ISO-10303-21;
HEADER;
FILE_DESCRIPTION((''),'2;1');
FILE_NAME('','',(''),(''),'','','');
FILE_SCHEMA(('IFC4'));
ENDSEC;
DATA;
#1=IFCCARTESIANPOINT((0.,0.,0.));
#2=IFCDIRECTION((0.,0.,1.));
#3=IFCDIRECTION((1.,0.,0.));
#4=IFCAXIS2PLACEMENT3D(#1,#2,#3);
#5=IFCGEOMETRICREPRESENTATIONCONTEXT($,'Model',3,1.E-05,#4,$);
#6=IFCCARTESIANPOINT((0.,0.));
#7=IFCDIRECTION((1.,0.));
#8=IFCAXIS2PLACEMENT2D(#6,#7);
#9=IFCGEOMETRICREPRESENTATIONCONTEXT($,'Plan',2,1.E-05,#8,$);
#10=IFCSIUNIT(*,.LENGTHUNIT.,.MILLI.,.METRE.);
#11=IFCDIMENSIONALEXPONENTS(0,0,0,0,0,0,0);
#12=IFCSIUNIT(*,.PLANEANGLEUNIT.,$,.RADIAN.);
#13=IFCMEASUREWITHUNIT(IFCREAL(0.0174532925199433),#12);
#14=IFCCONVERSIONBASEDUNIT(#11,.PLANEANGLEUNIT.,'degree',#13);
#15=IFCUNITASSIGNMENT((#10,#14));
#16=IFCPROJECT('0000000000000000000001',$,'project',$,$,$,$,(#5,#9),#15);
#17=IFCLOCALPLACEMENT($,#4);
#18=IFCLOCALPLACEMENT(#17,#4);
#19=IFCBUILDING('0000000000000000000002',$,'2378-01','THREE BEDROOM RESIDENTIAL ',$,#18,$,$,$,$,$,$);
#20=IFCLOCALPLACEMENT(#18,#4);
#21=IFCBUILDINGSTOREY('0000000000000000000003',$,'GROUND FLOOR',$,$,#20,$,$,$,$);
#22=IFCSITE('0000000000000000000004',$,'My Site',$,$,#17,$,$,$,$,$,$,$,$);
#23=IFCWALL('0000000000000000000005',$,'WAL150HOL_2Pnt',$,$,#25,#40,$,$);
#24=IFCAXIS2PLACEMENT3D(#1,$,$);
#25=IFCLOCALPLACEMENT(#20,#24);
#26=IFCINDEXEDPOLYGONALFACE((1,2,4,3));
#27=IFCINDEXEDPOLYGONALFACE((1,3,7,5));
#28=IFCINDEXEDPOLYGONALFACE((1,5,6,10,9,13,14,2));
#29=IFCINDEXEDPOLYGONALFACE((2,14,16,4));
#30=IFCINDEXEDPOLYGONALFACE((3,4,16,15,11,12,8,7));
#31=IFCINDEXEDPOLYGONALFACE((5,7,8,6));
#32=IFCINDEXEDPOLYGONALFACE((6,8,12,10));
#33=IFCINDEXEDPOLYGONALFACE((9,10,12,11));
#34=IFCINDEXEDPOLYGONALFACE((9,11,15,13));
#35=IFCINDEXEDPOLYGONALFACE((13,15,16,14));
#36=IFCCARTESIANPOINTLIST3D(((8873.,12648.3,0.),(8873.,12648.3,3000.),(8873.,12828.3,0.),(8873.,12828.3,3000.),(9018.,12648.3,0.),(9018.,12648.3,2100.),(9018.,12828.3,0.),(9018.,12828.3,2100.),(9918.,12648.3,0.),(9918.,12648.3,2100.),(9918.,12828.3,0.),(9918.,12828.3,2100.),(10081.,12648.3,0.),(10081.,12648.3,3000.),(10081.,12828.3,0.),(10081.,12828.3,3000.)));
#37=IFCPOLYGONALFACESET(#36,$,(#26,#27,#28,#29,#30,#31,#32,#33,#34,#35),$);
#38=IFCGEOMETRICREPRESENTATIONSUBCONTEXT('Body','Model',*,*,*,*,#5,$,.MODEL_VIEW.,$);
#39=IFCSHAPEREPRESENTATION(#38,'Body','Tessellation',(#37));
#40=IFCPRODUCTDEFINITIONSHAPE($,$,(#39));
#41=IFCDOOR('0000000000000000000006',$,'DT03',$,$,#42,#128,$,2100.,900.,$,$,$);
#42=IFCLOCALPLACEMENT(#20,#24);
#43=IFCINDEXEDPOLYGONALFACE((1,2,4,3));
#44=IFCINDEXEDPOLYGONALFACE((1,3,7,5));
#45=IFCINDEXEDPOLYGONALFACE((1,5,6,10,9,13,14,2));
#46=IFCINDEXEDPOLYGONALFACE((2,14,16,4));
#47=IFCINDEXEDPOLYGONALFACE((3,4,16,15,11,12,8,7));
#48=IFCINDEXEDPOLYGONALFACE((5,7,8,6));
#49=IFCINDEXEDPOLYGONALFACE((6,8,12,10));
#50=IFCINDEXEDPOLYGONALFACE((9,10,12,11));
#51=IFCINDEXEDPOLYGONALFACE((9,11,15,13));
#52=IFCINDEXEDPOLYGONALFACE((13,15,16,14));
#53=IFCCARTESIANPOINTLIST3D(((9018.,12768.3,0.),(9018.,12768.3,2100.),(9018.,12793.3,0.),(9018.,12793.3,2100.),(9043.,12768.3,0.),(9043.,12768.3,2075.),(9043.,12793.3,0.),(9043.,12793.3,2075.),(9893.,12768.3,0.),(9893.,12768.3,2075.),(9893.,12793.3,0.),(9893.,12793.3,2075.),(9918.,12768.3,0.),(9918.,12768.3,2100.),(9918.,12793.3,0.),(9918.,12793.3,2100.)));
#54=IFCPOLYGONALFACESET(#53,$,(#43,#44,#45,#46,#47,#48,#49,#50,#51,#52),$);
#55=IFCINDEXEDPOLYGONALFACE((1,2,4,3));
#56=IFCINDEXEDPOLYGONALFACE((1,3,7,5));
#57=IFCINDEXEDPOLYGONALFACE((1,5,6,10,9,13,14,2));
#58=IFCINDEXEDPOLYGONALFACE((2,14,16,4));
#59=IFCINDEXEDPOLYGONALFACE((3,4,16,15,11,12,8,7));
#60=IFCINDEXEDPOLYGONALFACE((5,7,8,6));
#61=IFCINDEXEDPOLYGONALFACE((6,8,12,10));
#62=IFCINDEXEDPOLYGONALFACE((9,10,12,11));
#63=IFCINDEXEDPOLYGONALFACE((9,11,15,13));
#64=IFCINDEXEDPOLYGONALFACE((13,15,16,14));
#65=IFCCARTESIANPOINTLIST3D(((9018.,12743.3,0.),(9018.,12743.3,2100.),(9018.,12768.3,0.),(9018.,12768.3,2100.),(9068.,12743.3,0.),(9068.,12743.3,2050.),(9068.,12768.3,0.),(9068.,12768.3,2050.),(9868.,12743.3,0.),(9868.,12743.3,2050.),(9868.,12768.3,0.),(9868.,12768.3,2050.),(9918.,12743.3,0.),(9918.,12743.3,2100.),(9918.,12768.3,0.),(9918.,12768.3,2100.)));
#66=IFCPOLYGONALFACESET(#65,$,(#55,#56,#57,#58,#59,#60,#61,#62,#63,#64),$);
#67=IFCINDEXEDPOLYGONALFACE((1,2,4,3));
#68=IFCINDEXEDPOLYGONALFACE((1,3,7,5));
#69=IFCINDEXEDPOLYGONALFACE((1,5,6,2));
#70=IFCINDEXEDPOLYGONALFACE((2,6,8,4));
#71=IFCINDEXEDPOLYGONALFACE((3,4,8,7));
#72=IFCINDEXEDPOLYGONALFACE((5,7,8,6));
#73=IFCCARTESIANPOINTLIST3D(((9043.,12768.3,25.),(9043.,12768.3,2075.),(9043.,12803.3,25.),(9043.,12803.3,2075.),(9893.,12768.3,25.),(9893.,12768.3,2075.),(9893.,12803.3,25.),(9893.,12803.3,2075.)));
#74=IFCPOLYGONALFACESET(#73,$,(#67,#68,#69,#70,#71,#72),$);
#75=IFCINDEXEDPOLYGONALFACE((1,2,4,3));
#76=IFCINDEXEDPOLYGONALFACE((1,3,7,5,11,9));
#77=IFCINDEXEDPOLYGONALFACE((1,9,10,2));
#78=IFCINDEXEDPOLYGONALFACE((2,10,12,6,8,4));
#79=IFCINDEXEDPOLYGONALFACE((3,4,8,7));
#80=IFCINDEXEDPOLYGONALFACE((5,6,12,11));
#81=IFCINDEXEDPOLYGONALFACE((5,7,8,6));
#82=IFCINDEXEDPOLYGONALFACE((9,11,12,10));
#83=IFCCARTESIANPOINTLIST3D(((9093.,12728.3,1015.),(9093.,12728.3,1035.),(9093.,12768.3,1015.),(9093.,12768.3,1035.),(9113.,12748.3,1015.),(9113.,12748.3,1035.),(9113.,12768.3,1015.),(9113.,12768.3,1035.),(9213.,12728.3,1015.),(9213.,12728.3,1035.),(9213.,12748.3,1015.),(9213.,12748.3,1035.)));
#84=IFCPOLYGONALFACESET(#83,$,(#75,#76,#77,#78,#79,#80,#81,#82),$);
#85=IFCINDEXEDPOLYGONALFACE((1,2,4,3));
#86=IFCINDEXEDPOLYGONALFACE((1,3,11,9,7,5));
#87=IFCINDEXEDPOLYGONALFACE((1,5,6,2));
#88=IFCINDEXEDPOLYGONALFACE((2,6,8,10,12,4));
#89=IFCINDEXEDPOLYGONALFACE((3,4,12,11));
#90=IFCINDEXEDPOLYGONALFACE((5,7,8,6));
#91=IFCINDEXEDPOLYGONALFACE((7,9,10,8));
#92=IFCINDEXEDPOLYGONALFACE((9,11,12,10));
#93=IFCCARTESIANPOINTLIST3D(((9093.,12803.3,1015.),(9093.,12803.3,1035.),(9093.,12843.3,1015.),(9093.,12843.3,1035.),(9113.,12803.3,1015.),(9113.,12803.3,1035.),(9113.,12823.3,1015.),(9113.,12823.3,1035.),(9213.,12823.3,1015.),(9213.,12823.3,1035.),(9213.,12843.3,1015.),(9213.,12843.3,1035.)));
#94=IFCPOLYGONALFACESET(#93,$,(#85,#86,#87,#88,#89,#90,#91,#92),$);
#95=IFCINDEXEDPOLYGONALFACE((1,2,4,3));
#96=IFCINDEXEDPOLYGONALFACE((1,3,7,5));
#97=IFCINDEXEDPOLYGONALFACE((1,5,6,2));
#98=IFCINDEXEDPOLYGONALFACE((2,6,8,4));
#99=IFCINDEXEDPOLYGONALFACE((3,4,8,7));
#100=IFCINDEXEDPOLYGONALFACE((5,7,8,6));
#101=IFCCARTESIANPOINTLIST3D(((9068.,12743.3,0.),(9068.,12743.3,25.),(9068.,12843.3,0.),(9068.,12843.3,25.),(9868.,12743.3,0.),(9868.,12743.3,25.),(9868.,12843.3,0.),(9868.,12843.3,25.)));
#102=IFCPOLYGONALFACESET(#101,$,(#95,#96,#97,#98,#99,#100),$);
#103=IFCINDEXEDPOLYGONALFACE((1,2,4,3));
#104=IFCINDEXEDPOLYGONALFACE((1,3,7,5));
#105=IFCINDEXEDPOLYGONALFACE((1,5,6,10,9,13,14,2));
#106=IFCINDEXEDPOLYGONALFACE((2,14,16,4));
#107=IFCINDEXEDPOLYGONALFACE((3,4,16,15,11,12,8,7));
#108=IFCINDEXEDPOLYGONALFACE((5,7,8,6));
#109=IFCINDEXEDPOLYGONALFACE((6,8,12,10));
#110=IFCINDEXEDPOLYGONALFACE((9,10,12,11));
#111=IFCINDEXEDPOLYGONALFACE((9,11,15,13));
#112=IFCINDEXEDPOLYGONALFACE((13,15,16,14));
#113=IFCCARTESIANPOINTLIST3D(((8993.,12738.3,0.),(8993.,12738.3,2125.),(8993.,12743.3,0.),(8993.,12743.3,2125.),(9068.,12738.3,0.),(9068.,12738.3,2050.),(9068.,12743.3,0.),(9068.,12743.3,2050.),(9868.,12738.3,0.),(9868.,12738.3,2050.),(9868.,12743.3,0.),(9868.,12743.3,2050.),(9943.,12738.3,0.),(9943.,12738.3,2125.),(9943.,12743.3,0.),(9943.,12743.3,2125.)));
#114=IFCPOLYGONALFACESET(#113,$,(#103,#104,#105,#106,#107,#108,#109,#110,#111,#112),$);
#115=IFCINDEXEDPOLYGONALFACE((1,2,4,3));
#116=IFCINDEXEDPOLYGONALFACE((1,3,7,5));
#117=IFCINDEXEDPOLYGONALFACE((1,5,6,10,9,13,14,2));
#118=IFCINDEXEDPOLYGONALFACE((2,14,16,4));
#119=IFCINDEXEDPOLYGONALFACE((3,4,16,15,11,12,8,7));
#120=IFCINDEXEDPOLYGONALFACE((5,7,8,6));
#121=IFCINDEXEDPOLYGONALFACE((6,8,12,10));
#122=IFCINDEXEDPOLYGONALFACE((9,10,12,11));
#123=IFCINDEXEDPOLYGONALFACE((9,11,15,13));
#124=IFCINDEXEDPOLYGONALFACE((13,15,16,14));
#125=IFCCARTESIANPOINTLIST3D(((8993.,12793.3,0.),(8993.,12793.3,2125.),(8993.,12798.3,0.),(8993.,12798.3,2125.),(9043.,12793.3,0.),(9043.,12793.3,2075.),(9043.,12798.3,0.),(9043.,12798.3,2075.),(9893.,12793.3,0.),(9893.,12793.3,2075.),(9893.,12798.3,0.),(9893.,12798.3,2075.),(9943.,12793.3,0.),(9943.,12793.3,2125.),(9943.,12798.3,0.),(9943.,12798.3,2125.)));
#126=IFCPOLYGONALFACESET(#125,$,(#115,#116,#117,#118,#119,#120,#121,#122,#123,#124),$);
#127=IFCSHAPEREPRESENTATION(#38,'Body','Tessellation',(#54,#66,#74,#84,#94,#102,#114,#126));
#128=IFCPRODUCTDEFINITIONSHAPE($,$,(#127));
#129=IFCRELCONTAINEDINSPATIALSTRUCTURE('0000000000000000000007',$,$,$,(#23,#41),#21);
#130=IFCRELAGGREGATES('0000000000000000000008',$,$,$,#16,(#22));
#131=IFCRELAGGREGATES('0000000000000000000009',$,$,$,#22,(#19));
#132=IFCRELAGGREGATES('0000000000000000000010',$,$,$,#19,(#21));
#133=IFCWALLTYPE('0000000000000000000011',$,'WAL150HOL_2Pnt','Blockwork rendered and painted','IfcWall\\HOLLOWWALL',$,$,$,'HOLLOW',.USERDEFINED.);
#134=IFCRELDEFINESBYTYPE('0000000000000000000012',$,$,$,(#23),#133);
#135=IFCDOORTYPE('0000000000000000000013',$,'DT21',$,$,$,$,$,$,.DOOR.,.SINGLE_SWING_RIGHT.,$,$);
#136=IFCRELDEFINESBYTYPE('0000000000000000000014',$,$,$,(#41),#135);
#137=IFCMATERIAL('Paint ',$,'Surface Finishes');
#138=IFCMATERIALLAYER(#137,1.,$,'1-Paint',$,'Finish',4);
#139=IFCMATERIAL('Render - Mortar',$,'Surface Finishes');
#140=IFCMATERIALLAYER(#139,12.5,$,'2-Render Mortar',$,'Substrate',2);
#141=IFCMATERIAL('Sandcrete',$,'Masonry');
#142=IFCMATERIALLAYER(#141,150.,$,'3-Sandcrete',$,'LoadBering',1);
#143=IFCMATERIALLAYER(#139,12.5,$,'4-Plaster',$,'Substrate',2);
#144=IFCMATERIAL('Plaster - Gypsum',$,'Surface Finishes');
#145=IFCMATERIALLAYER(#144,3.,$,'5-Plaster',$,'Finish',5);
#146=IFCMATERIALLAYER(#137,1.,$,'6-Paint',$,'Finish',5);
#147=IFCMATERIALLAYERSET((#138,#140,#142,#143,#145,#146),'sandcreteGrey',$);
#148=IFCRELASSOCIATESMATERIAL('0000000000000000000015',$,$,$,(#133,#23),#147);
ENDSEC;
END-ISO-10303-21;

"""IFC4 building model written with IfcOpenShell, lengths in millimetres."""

from ifc_helpers import new_model, entity, si_unit, converted_unit, frame, origin_with_axes, origin_2d_with_axis, place, context, subcontext, project, spatial, line, indexed_curve, outline, extrude, shape, source, transform, mapped, material, layer, layer_set, layer_usage, type_object, type_shapes, element, fill, save


model = new_model("IFC4")

# Units and contexts
model_context = context("Model", 3, precision=1e-05, world=origin_with_axes())
plan_context = context("Plan", 2, precision=1e-05, world=origin_2d_with_axis())
body_context_1 = subcontext(model_context, "Body", "Model", "MODEL_VIEW")
body_context_2 = subcontext(plan_context, "Body", "Plan", "PLAN_VIEW")
ifc_project = project(units=[si_unit("LENGTHUNIT", "METRE", prefix="MILLI"), converted_unit("PLANEANGLEUNIT", "degree", entity("IfcReal", 0.0174532925199433), si_unit("PLANEANGLEUNIT", "RADIAN"), dimensions=[0, 0, 0, 0, 0, 0, 0])], contexts=[model_context, plan_context])

# Site, building, storey
site_placement = place(None, origin_with_axes())
site = spatial("IfcSite", under=ifc_project, at=site_placement, Name="My Site")
building_placement = place(site_placement, origin_with_axes())
building = spatial("IfcBuilding", under=site, at=building_placement, Name="2378-01", Description="THREE BEDROOM RESIDENTIAL ")
storey_placement = place(building_placement, origin_with_axes())
storey = spatial("IfcBuildingStorey", under=building, at=storey_placement, Name="GROUND FLOOR")

# Shared definitions
ifc_material_1 = material(Name="Paint ", Category="Surface Finishes")
ifc_layer_1 = layer(ifc_material_1, 1.0, Name="1-Paint", Category="Finish", Priority=4)
ifc_material_2 = material(Name="Render - Mortar", Category="Surface Finishes")
ifc_layer_2 = layer(ifc_material_2, 12.5, Name="2-Render Mortar", Category="Substrate", Priority=2)
ifc_material_3 = material(Name="Sandcrete", Category="Masonry")
ifc_layer_3 = layer(ifc_material_3, 150.0, Name="3-Sandcrete", Category="LoadBering", Priority=1)
ifc_layer_4 = layer(ifc_material_2, 12.5, Name="4-Plaster", Category="Substrate", Priority=2)
ifc_material_4 = material(Name="Plaster - Gypsum", Category="Surface Finishes")
ifc_layer_5 = layer(ifc_material_4, 3.0, Name="5-Plaster", Category="Finish", Priority=5)
ifc_layer_6 = layer(ifc_material_1, 1.0, Name="6-Paint", Category="Finish", Priority=5)
ifc_layer_set_1 = layer_set([ifc_layer_1, ifc_layer_2, ifc_layer_3, ifc_layer_4, ifc_layer_5, ifc_layer_6], Name="sandcreteGrey")
wall_type_1 = type_object("IfcWallType", Name="WAL150HOL_2Pnt", Description="Blockwork rendered and painted", ApplicableOccurrence="IfcWall\\HOLLOWWALL", ElementType="HOLLOW", PredefinedType="USERDEFINED", material=ifc_layer_set_1)

# Shared definitions
shared_shape_1 = source(origin_with_axes(), body_context_1, "Body", "SweptSolid", [
    extrude(outline(indexed_curve([(0.0, 0.0), (900.0, 0.0), (900.0, 2100.0), (0.0, 2100.0)], segments=[line(1, 2, 3, 4, 1)])), frame((0.0, -600.0, 0.0), z_axis=(0.0, -1.0, 0.0), x_axis=(1.0, 0.0, 0.0)), (0.0, 0.0, -1.0), 1200.0),
])
door_type_1 = type_object("IfcDoorType", Name="DT21", OperationType="SINGLE_SWING_RIGHT", PredefinedType="DOOR")
shared_shape_2 = source(origin_with_axes(), body_context_1, "Body", "SweptSolid", [
    extrude(outline(indexed_curve([(0.0, 0.0), (0.0, 2100.0), (900.0, 2100.0), (900.0, 0.0), (875.0, 0.0), (875.0, 2075.0), (25.0, 2075.0), (25.0, 0.0)], segments=[line(1, 2, 3, 4, 5, 6, 7, 8, 1)])), frame((0.0, 25.0, 0.0), z_axis=(0.0, -1.0, 0.0), x_axis=(1.0, 0.0, 0.0)), (0.0, 0.0, -1.0), 25.0),
    extrude(outline(indexed_curve([(0.0, 0.0), (0.0, 2100.0), (900.0, 2100.0), (900.0, 0.0), (850.0, 0.0), (850.0, 2050.0), (50.0, 2050.0), (50.0, 0.0)], segments=[line(1, 2, 3, 4, 5, 6, 7, 8, 1)])), frame((0.0, 0.0, 0.0), z_axis=(0.0, -1.0, 0.0), x_axis=(1.0, 0.0, 0.0)), (0.0, 0.0, -1.0), 25.0),
    extrude(outline(indexed_curve([(0.0, 0.0), (850.0, 0.0), (850.0, 35.0), (0.0, 35.0)], segments=[line(1, 2, 3, 4, 1)])), frame((25.0, 25.0, 25.0), z_axis=(0.0, 0.0, 1.0), x_axis=(1.0, 0.0, 0.0)), (0.0, 0.0, 1.0), 2050.0),
    extrude(outline(indexed_curve([(0.0, 0.0), (0.0, -40.0), (120.0, -40.0), (120.0, -20.0), (20.0, -20.0), (20.0, 0.0)], segments=[line(1, 2, 3, 4, 5, 6, 1)])), frame((75.0, 25.0, 1015.0), z_axis=(0.0, 0.0, 1.0), x_axis=(1.0, 0.0, 0.0)), (0.0, 0.0, 1.0), 20.0),
    extrude(outline(indexed_curve([(0.0, 0.0), (0.0, 40.0), (120.0, 40.0), (120.0, 20.0), (20.0, 20.0), (20.0, 0.0)], segments=[line(1, 2, 3, 4, 5, 6, 1)])), frame((75.0, 60.0, 1015.0), z_axis=(0.0, 0.0, 1.0), x_axis=(1.0, 0.0, 0.0)), (0.0, 0.0, 1.0), 20.0),
    extrude(outline(indexed_curve([(0.0, 0.0), (800.0, 0.0), (800.0, 100.0), (0.0, 100.0)], segments=[line(1, 2, 3, 4, 1)])), frame((50.0, 0.0, 0.0), z_axis=(0.0, 0.0, 1.0), x_axis=(1.0, 0.0, 0.0)), (0.0, 0.0, 1.0), 25.0),
    extrude(outline(indexed_curve([(0.0, 0.0), (0.0, 2125.0), (950.0, 2125.0), (950.0, 0.0), (875.0, 0.0), (875.0, 2050.0), (75.0, 2050.0), (75.0, 0.0)], segments=[line(1, 2, 3, 4, 5, 6, 7, 8, 1)])), frame((-25.0, -5.0, 0.0), z_axis=(0.0, -1.0, 0.0), x_axis=(1.0, 0.0, 0.0)), (0.0, 0.0, -1.0), 5.0),
    extrude(outline(indexed_curve([(0.0, 0.0), (0.0, 2125.0), (950.0, 2125.0), (950.0, 0.0), (900.0, 0.0), (900.0, 2075.0), (50.0, 2075.0), (50.0, 0.0)], segments=[line(1, 2, 3, 4, 5, 6, 7, 8, 1)])), frame((-25.0, 50.0, 0.0), z_axis=(0.0, -1.0, 0.0), x_axis=(1.0, 0.0, 0.0)), (0.0, 0.0, -1.0), 5.0),
])
shared_shape_3 = source(origin_with_axes(), body_context_2, "Body", "Curve2D", [
    entity("IfcIndexedPolyCurve", entity("IfcCartesianPointList2D", [[0.0, 0.0], [0.0, 50.0], [25.0, 50.0], [25.0, 25.0], [50.0, 25.0], [50.0, 0.0]]), [entity("IfcLineIndex", [1, 2, 3, 4, 5, 6, 1])]),
    entity("IfcIndexedPolyCurve", entity("IfcCartesianPointList2D", [[900.0, 0.0], [900.0, 50.0], [875.0, 50.0], [875.0, 25.0], [850.0, 25.0], [850.0, 0.0]]), [entity("IfcLineIndex", [1, 2, 3, 4, 5, 6, 1])]),
    entity("IfcTrimmedCurve", entity("IfcEllipse", entity("IfcAxis2Placement2D", entity("IfcCartesianPoint", [840.0, 50.0]), entity("IfcDirection", [1.0, 0.0])), 815.0, 850.0), [entity("IfcCartesianPoint", [840.0, 900.0])], [entity("IfcCartesianPoint", [25.0, 50.0])], True, "CARTESIAN"),
    entity("IfcIndexedPolyCurve", entity("IfcCartesianPointList2D", [[875.0, 50.0], [840.0, 50.0], [840.0, 900.0], [875.0, 900.0]]), [entity("IfcLineIndex", [1, 2, 3, 4, 1])]),
])
type_shapes(door_type_1, [shared_shape_2, shared_shape_3])

# Wall, opening, door
ifc_layer_usage_1 = layer_usage(ifc_layer_set_1, "AXIS2", "POSITIVE", 0.0)
wall_1_placement = place(storey_placement, frame((10081.0, 12828.3, 0.0), z_axis=(0.0, 0.0, 1.0), x_axis=(-1.0, 0.000001, 0.0)))
wall_1 = element("IfcWall", 1, at=wall_1_placement, inside=storey, type_object=wall_type_1, material=ifc_layer_usage_1, Name="WAL150HOL_2Pnt", context=body_context_1, shape_type="SweptSolid", body=[
    extrude(outline(indexed_curve([(0.0, 0.0), (0.0, 180.0), (1208.0, 180.0), (1208.0, 0.0), (0.0, 0.0)], self_intersect=False)), origin_with_axes(), (0.0, 0.0, 1.0), 3000.0),
])
opening_1_placement = place(wall_1_placement, frame((1063.0, 85.0, 0.0), z_axis=(0.0, 0.0, 1.0), x_axis=(-1.0, 0.0, 0.0)))
opening_1 = element("IfcOpeningElement", 2, at=opening_1_placement, cuts=wall_1, PredefinedType="OPENING", context=body_context_1, shape_type="MappedRepresentation", body=[
    mapped(shared_shape_1, transform((0.0, 0.0, 0.0), x_axis=(1.0, 0.0, 0.0), y_axis=(0.0, 1.0, 0.0), z_axis=(0.0, 0.0, 1.0), scale=1.0)),
])
door_1_placement = place(opening_1_placement, origin_with_axes())
door_1 = element("IfcDoor", 3, at=door_1_placement, inside=storey, type_object=door_type_1, Name="DT03", OverallHeight=2100.0, OverallWidth=900.0, shapes=[
    shape(body_context_1, "Body", "MappedRepresentation", [mapped(shared_shape_2, transform((0.0, 0.0, 0.0), x_axis=(1.0, 0.0, 0.0), y_axis=(0.0, 1.0, 0.0), z_axis=(0.0, 0.0, 1.0), scale=1.0))]),
    shape(body_context_2, "Body", "MappedRepresentation", [mapped(shared_shape_3, transform((0.0, 0.0, 0.0), x_axis=(1.0, 0.0, 0.0), y_axis=(0.0, 1.0, 0.0), z_axis=(0.0, 0.0, 1.0), scale=1.0))]),
])
fill(opening_1, door_1)

save(model, "model.ifc")
